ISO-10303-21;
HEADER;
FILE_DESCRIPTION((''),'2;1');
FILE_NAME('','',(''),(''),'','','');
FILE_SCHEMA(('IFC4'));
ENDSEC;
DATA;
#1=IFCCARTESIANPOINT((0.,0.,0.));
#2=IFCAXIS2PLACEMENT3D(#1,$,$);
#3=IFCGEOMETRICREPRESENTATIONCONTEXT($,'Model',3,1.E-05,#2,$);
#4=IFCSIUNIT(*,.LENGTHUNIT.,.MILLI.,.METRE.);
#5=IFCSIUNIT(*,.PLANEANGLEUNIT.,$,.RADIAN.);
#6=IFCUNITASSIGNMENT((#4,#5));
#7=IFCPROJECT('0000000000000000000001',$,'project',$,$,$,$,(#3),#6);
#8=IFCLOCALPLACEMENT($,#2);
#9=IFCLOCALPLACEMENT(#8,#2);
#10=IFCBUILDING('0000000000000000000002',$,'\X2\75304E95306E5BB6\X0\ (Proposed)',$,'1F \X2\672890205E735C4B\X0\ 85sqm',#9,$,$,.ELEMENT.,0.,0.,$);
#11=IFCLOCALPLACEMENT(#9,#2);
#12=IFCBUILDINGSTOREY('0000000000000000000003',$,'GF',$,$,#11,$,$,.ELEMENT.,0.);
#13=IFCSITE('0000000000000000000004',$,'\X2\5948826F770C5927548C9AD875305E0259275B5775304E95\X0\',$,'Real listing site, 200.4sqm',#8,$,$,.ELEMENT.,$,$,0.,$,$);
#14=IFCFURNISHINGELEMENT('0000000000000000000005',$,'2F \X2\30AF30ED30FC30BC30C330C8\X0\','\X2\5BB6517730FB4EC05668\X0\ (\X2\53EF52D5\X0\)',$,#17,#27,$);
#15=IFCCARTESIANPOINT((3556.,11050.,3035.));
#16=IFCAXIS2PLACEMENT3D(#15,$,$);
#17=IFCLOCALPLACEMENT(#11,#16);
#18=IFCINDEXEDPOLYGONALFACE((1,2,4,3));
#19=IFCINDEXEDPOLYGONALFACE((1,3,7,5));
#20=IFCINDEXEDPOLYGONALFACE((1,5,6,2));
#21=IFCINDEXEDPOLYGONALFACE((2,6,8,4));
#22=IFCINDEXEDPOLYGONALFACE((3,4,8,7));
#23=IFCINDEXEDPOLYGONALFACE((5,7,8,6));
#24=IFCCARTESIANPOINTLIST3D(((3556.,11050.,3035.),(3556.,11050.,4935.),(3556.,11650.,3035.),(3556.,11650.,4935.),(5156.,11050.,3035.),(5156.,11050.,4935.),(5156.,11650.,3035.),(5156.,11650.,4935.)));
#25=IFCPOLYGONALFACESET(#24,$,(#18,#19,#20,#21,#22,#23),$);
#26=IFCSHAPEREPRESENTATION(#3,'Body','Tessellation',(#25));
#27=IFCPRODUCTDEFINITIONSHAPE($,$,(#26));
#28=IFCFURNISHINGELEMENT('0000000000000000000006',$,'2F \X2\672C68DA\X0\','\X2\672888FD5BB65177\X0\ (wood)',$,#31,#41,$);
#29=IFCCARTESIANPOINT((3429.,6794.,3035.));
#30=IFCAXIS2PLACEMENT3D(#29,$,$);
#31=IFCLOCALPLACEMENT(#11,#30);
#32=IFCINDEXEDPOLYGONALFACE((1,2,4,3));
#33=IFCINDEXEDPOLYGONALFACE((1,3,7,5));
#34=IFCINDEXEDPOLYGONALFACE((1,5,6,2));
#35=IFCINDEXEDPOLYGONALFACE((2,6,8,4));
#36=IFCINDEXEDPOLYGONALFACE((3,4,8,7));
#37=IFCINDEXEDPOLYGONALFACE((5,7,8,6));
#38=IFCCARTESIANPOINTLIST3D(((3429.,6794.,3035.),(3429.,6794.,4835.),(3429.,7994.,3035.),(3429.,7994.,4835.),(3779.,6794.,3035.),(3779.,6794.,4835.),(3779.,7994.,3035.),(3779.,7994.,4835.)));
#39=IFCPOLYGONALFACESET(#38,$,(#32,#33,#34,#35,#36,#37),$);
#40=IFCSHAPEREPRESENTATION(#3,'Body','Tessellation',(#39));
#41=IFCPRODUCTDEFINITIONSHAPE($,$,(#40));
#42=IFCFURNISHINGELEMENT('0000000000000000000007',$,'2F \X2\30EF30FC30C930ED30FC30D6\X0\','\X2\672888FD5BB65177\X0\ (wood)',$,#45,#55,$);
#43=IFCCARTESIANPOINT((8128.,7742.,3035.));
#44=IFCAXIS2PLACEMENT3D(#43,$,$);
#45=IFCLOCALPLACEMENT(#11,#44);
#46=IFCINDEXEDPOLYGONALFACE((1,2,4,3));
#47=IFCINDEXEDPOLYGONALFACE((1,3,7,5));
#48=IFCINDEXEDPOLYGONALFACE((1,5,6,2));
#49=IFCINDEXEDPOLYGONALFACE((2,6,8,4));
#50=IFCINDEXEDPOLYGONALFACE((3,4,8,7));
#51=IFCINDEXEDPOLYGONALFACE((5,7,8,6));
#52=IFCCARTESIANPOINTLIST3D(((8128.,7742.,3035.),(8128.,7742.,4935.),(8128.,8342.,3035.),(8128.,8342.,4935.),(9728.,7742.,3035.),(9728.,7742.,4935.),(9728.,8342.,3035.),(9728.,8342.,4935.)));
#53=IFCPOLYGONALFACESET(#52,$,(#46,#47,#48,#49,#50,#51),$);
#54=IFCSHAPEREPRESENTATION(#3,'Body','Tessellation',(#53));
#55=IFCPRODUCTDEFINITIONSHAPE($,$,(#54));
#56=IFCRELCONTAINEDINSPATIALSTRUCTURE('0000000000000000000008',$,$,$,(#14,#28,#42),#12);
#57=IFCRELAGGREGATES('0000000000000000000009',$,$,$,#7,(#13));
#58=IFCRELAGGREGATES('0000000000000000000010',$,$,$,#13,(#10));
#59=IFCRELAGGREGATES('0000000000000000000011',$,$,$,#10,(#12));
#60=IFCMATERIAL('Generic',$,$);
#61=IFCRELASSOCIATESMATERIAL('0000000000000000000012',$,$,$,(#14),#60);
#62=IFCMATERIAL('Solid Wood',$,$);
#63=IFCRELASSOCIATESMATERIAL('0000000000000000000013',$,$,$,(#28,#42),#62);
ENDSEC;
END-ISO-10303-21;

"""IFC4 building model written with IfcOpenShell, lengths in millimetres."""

from ifc_helpers import new_model, si_unit, frame, frame_2d, origin, place, context, project, spatial, rectangle, extrude, material, element, save


model = new_model("IFC4")

# Units and contexts
model_context = context("Model", 3, precision=1e-05, world=origin())
ifc_project = project(units=[si_unit("LENGTHUNIT", "METRE", prefix="MILLI"), si_unit("PLANEANGLEUNIT", "RADIAN")], contexts=[model_context])

# Site, building, storey
site_placement = place(None, origin())
site = spatial("IfcSite", under=ifc_project, at=site_placement, Name="奈良県大和高田市大字田井", ObjectType="Real listing site, 200.4sqm", CompositionType="ELEMENT", RefElevation=0.0)
building_placement = place(site_placement, origin())
building = spatial("IfcBuilding", under=site, at=building_placement, Name="田井の家 (Proposed)", ObjectType="1F 木造平屋 85sqm", CompositionType="ELEMENT", ElevationOfRefHeight=0.0, ElevationOfTerrain=0.0)
storey_placement = place(building_placement, origin())
storey = spatial("IfcBuildingStorey", under=building, at=storey_placement, Name="GF", CompositionType="ELEMENT", Elevation=0.0)

# Shared definitions
ifc_material_1 = material(Name="Solid Wood")

# Shared definitions
ifc_material_2 = material(Name="Generic")

# Furnishing elements
furnishing_1_placement = place(storey_placement, frame((3556.0, 11050.0, 3035.0)))
element("IfcFurnishingElement", 1, at=furnishing_1_placement, inside=storey, material=ifc_material_2, Name="2F クローゼット", Description="家具・什器 (可動)", context=model_context, shape_type="SweptSolid", body=[
    extrude(rectangle(XDim=1600.0, YDim=600.0, at=frame_2d((800.0, 300.0))), frame((3556.0, 11050.0, 3035.0)), (0.0, 0.0, 1.0), 1900.0),
])
furnishing_2_placement = place(storey_placement, frame((3429.0, 6794.0, 3035.0)))
element("IfcFurnishingElement", 2, at=furnishing_2_placement, inside=storey, material=ifc_material_1, Name="2F 本棚", Description="木製家具 (wood)", context=model_context, shape_type="SweptSolid", body=[
    extrude(rectangle(XDim=350.0, YDim=1200.0, at=frame_2d((175.0, 600.0))), frame((3429.0, 6794.0, 3035.0)), (0.0, 0.0, 1.0), 1800.0),
])
furnishing_3_placement = place(storey_placement, frame((8128.0, 7742.0, 3035.0)))
element("IfcFurnishingElement", 3, at=furnishing_3_placement, inside=storey, material=ifc_material_1, Name="2F ワードローブ", Description="木製家具 (wood)", context=model_context, shape_type="SweptSolid", body=[
    extrude(rectangle(XDim=1600.0, YDim=600.0, at=frame_2d((800.0, 300.0))), frame((8128.0, 7742.0, 3035.0)), (0.0, 0.0, 1.0), 1900.0),
])

save(model, "model.ifc")
